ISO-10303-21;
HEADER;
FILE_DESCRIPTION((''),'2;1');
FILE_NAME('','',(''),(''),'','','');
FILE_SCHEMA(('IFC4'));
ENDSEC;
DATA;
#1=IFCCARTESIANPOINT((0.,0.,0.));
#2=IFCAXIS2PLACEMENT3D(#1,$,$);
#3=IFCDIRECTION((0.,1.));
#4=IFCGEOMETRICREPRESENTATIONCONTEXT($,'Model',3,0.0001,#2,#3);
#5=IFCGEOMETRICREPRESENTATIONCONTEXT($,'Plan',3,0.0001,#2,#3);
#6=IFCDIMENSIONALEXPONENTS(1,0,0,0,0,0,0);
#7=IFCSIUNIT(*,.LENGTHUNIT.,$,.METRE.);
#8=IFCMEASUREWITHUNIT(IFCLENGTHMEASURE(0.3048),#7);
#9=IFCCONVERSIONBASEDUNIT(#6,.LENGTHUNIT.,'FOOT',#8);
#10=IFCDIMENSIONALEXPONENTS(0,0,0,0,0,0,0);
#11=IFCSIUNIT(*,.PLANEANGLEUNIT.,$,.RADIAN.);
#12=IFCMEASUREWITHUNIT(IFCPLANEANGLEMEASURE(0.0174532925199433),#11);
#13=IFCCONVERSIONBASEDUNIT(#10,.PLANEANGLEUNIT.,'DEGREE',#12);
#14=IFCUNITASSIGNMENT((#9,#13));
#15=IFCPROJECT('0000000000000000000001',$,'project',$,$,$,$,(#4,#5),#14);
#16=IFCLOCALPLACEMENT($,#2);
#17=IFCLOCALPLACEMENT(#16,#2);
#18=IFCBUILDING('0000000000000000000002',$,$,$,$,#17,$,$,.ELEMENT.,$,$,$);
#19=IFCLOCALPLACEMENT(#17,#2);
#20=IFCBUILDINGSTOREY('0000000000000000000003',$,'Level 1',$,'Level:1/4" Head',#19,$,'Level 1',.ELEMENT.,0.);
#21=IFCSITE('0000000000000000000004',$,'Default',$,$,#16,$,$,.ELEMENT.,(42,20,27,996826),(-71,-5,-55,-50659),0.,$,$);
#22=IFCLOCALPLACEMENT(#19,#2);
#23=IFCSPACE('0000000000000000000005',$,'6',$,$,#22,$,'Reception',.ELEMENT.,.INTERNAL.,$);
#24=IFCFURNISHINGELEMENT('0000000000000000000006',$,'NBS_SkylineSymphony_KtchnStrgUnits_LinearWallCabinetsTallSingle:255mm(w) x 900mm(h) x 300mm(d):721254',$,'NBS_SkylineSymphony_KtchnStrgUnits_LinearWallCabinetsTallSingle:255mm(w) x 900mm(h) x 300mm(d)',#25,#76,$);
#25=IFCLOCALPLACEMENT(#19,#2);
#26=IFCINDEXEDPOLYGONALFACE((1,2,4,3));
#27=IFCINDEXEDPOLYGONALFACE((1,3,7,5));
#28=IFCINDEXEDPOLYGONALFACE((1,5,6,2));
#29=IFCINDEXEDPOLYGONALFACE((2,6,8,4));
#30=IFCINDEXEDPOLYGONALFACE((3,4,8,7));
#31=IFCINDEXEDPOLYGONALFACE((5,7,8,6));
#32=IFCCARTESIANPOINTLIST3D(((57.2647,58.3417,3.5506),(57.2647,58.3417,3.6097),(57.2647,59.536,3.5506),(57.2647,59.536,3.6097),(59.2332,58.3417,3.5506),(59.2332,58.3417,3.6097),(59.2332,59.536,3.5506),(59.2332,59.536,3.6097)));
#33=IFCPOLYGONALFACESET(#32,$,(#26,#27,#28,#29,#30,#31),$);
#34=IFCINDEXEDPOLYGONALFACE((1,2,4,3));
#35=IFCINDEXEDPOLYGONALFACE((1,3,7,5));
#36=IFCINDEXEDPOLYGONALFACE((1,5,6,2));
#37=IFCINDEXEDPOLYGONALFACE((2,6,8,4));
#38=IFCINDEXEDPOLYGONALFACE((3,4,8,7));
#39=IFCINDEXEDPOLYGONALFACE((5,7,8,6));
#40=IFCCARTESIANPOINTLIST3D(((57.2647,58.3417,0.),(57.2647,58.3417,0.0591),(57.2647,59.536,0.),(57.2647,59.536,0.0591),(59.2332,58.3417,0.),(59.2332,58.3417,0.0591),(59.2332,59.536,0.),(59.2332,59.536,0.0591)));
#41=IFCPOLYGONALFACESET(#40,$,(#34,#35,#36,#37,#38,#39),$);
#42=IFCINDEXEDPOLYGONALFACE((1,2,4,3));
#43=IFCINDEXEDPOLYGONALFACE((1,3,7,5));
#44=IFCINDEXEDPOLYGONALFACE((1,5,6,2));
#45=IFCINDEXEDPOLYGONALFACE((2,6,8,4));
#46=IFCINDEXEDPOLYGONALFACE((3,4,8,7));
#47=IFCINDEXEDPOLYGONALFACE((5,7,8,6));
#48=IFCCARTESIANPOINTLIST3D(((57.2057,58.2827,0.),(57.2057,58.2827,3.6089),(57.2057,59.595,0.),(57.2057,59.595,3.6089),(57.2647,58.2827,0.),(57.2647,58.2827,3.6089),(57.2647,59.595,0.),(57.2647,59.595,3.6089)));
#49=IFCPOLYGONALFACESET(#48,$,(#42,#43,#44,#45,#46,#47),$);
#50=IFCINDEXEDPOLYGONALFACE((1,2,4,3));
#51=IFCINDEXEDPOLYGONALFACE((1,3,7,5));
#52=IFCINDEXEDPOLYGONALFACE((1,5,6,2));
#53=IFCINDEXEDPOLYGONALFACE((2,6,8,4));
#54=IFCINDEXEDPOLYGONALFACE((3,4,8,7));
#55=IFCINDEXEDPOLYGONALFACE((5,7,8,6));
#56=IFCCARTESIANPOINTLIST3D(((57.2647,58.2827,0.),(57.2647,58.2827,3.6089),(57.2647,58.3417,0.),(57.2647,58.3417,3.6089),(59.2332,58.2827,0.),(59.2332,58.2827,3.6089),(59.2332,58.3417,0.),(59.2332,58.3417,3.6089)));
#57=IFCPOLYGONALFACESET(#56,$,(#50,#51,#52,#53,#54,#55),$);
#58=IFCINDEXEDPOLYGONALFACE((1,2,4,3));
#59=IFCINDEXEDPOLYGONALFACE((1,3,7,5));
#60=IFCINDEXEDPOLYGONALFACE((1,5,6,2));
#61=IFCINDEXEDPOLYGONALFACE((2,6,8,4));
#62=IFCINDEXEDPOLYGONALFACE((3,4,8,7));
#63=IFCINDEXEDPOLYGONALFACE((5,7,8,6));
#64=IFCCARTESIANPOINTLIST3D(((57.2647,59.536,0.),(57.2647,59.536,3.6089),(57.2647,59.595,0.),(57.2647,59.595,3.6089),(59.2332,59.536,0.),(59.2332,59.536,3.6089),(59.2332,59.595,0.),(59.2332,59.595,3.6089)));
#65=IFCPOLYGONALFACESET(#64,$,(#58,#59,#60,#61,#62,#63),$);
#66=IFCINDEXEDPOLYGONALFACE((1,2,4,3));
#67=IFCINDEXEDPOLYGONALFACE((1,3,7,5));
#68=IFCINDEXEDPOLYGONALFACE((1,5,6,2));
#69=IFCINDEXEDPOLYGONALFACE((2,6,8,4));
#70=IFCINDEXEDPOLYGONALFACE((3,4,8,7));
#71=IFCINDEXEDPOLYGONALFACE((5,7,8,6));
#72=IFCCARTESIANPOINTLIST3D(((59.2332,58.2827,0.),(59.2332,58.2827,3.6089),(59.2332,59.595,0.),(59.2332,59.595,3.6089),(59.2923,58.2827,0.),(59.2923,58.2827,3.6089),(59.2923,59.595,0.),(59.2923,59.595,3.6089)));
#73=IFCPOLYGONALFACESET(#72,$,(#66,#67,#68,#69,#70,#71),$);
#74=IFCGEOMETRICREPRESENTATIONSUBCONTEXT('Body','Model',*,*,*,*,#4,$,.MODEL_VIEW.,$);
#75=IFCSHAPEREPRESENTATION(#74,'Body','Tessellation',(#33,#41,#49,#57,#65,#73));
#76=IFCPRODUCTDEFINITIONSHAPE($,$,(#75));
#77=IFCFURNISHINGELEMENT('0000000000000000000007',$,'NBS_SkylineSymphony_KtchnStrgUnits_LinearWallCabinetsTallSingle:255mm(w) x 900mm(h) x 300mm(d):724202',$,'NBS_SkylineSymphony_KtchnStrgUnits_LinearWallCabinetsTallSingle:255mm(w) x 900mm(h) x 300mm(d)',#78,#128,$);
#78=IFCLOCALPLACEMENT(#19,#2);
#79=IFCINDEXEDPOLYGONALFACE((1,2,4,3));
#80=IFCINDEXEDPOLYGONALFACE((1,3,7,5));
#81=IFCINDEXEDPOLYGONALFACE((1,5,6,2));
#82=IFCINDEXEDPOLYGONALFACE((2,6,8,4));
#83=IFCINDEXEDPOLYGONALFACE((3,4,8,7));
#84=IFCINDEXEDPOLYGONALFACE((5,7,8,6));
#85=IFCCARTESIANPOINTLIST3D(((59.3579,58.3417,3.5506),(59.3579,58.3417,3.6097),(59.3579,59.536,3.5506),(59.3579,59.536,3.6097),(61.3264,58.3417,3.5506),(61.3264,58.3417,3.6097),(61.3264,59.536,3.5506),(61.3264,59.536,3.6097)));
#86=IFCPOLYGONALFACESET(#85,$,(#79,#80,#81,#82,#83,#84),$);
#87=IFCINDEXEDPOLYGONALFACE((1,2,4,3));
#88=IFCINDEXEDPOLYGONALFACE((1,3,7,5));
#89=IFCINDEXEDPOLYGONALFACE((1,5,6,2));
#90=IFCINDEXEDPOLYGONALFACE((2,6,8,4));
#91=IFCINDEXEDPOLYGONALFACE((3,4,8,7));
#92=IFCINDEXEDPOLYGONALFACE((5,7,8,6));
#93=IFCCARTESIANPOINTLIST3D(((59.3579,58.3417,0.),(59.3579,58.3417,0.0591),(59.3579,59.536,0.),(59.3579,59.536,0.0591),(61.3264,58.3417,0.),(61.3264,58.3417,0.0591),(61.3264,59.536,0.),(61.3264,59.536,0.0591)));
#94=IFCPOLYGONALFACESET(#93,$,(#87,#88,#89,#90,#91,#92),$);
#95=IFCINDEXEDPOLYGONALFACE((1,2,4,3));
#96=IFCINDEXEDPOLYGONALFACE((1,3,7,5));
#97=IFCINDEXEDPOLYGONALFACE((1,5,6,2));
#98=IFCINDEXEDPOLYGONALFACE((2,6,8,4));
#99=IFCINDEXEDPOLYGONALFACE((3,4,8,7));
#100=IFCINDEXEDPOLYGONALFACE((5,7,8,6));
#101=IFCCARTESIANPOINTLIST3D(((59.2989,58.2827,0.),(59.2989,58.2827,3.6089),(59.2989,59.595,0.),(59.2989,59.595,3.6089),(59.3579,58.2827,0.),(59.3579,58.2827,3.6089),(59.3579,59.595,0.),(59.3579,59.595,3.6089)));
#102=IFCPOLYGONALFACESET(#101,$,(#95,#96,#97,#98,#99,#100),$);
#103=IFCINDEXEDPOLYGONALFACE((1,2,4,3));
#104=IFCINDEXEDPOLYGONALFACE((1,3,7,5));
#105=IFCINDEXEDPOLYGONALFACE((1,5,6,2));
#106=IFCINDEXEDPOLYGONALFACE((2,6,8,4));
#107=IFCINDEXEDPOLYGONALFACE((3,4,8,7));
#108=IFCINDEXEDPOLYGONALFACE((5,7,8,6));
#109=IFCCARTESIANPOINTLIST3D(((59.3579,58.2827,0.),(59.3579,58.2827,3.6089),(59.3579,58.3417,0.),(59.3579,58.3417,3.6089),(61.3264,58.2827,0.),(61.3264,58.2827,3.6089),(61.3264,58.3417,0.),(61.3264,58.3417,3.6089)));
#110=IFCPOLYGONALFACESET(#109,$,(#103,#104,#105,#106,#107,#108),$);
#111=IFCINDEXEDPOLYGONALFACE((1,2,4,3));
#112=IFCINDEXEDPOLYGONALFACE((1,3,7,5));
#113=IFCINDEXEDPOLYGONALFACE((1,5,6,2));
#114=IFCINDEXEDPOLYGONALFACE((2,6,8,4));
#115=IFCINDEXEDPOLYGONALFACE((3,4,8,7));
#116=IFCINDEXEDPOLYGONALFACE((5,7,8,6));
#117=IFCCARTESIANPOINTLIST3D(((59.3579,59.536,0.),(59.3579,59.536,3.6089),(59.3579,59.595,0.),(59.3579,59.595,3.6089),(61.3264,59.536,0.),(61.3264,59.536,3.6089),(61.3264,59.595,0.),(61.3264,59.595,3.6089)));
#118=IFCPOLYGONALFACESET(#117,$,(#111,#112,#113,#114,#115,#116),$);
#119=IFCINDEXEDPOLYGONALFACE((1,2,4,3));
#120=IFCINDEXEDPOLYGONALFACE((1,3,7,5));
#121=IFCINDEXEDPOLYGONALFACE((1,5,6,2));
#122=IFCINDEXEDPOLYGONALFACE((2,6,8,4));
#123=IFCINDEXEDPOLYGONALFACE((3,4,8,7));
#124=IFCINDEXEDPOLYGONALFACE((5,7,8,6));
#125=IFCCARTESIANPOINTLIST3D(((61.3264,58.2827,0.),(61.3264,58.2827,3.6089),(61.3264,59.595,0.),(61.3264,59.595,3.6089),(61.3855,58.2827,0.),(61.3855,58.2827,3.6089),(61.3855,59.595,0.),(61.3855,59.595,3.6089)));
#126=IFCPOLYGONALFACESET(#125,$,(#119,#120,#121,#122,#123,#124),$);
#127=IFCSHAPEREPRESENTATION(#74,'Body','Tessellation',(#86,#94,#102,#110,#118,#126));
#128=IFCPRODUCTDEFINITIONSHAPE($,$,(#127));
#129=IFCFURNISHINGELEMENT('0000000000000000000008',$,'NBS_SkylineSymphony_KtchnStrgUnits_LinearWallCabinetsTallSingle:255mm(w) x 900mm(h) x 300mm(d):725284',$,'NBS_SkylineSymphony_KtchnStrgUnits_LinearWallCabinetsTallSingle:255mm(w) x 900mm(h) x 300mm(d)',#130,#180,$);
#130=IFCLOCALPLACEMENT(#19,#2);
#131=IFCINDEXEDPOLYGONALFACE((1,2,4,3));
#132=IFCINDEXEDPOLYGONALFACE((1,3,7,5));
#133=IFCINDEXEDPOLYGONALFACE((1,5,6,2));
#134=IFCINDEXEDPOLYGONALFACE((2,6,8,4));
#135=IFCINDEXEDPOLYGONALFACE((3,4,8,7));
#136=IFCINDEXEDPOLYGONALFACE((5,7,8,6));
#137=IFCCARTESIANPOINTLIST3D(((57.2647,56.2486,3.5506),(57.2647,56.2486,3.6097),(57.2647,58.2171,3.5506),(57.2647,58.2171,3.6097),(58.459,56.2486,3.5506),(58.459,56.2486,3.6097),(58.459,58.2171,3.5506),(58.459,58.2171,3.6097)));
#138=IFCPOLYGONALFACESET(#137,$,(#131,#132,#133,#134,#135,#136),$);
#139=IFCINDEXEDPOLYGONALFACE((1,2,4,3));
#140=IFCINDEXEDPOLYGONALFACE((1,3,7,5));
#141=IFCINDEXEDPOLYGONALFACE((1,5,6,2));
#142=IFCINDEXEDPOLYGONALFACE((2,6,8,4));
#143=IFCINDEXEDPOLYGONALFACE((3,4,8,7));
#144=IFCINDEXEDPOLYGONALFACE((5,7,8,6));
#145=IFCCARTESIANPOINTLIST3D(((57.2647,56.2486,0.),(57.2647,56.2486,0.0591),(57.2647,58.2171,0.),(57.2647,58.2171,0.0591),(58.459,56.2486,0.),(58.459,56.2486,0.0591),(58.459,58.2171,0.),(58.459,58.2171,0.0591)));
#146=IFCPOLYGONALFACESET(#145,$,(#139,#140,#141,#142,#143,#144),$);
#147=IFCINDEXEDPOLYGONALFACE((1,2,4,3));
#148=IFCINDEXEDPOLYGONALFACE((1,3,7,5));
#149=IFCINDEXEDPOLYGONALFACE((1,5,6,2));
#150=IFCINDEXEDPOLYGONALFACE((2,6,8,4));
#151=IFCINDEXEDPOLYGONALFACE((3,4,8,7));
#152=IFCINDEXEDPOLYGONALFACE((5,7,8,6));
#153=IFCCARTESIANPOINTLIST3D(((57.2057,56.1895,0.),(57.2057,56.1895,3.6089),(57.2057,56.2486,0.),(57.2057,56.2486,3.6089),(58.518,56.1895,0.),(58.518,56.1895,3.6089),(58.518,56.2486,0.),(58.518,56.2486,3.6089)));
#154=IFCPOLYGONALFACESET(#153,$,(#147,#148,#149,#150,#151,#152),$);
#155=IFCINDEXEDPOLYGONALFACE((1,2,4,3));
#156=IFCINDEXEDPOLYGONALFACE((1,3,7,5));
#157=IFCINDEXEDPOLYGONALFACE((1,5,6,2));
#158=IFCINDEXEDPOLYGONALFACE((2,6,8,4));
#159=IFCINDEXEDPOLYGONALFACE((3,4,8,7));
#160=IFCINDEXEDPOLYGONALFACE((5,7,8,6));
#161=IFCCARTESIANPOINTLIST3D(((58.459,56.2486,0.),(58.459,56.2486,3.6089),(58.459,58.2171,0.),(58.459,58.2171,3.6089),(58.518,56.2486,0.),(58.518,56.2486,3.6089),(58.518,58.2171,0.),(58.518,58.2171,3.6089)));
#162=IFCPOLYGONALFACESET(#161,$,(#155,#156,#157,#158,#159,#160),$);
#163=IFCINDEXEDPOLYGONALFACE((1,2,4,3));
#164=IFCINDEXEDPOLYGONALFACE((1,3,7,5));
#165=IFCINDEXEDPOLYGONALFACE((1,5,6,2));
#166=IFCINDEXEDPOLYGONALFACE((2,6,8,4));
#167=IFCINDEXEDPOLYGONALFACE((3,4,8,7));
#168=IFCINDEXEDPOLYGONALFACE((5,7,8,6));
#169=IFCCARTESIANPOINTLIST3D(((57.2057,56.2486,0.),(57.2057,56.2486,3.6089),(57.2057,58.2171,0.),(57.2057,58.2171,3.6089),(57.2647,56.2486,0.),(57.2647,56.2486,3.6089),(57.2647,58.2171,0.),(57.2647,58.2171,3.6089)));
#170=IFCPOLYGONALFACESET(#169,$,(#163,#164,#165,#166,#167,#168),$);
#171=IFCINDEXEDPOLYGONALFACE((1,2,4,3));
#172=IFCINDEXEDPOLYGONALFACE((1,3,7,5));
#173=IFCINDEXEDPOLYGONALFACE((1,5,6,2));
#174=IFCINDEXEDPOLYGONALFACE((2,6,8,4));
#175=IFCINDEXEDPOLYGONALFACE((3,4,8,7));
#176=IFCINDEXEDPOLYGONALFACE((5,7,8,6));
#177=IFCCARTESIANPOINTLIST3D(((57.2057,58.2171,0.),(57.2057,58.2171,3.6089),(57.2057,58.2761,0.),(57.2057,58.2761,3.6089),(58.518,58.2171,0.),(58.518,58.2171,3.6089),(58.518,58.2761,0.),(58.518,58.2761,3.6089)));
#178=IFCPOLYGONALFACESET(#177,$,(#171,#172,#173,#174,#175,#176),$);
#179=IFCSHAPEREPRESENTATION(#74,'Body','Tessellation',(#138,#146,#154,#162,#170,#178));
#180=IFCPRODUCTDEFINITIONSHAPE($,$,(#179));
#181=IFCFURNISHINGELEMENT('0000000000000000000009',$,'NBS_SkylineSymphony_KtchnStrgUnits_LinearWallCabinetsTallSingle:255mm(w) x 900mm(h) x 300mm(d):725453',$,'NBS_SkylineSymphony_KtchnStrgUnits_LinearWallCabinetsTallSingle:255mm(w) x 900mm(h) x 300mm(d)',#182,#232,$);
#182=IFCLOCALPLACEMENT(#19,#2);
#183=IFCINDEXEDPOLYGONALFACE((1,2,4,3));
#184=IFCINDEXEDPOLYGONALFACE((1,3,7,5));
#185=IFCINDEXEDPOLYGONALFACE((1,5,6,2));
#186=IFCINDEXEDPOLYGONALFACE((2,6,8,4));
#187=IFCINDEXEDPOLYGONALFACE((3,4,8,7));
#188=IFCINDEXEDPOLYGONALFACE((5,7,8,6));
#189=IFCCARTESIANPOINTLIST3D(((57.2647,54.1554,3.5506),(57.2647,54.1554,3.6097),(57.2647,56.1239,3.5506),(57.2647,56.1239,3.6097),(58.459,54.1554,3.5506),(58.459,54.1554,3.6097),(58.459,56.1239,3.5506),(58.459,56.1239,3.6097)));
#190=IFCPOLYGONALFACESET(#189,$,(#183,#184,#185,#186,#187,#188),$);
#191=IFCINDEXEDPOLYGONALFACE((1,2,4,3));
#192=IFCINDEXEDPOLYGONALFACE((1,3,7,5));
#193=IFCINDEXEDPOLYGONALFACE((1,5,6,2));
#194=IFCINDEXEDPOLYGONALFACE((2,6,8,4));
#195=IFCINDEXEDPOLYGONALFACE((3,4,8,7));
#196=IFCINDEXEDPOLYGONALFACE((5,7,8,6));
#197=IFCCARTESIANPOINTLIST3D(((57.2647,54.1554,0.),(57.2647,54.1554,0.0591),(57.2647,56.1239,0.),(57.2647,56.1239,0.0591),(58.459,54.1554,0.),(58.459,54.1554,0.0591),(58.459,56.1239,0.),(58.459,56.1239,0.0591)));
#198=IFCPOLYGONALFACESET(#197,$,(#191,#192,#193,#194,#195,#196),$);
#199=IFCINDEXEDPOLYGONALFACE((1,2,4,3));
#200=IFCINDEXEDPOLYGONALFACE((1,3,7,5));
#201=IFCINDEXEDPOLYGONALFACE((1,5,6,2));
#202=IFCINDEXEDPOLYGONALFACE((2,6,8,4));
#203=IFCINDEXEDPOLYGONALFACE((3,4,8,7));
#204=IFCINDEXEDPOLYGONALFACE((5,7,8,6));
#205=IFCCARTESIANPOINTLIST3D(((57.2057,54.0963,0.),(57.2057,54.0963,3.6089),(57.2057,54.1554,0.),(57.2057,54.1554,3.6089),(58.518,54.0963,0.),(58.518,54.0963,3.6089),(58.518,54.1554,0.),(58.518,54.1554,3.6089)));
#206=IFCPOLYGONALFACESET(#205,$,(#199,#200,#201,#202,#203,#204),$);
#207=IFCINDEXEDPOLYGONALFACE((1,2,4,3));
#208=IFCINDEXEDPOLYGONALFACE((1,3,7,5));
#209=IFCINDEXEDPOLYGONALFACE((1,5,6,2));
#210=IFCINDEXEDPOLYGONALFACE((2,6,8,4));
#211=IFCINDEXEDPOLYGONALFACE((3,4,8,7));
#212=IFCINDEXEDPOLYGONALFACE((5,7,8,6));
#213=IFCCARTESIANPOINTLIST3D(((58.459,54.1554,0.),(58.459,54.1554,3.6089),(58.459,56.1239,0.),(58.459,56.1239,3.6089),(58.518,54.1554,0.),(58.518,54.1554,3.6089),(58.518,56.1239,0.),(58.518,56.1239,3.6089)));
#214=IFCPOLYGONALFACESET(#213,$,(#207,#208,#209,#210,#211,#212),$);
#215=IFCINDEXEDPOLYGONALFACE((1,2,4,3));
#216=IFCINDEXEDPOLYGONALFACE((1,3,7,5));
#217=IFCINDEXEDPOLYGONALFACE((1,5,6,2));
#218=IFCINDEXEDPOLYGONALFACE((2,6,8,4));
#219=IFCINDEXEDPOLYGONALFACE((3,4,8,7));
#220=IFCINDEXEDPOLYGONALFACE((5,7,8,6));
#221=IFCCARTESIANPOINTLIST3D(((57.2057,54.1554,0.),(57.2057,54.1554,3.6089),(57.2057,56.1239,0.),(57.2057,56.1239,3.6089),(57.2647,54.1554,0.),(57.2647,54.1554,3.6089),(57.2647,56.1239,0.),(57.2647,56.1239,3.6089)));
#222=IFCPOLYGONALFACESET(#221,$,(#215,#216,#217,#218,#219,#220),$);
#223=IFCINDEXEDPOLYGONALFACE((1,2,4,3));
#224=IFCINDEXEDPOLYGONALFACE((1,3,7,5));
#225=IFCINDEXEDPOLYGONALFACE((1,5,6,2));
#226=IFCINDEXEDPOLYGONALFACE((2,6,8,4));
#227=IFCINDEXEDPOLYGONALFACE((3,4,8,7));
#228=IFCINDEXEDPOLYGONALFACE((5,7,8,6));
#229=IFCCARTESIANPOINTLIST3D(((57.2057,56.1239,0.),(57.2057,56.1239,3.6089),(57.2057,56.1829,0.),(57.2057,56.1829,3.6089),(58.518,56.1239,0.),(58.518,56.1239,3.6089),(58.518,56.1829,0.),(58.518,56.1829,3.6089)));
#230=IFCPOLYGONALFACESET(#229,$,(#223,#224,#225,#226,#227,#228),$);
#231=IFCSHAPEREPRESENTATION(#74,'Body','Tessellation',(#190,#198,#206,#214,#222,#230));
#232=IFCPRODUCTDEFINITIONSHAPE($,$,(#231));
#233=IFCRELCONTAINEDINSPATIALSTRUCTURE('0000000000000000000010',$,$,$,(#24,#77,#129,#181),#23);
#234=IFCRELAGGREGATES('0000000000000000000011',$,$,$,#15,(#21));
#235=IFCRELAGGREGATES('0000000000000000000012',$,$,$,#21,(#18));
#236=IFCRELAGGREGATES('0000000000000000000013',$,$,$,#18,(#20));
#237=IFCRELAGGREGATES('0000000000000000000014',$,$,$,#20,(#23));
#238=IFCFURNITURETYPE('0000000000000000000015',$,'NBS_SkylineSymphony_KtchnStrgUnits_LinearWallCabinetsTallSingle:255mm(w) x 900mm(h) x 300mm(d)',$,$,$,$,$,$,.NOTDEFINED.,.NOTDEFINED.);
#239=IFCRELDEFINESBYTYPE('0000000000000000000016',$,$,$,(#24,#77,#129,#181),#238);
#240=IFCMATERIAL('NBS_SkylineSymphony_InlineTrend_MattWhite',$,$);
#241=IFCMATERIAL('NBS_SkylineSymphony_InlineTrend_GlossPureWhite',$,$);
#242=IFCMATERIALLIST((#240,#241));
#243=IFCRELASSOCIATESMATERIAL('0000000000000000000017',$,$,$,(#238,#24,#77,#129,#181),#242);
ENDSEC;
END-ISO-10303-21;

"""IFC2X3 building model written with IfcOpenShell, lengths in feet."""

from ifc_helpers import new_model, entity, si_unit, converted_unit, direction, frame, frame_2d, origin, origin_2d_with_axis, place, context, subcontext, project, spatial, rectangle, extrude, source, transform, mapped, material, material_list, type_object, type_shapes, element, save


model = new_model("IFC2X3")

# Units and contexts
model_context = context("Model", 3, precision=0.0001, world=origin(), true_north=direction((0.0, 1.0)))
plan_context = context("Plan", 3, precision=0.0001, world=origin(), true_north=direction((0.0, 1.0)))
body_context = subcontext(model_context, "Body", "Model", "MODEL_VIEW")
ifc_project = project(units=[converted_unit("LENGTHUNIT", "FOOT", entity("IfcLengthMeasure", 0.3048), si_unit("LENGTHUNIT", "METRE"), dimensions=[1, 0, 0, 0, 0, 0, 0]), converted_unit("PLANEANGLEUNIT", "DEGREE", entity("IfcPlaneAngleMeasure", 0.0174532925199433), si_unit("PLANEANGLEUNIT", "RADIAN"), dimensions=[0, 0, 0, 0, 0, 0, 0])], contexts=[model_context, plan_context])

# Site, building, storey
site_placement = place(None, origin())
site = spatial("IfcSite", under=ifc_project, at=site_placement, Name="Default", CompositionType="ELEMENT", RefLatitude=(42, 20, 27, 996826), RefLongitude=(-71, -5, -55, -50659), RefElevation=0.0)
building_placement = place(site_placement, origin())
building = spatial("IfcBuilding", under=site, at=building_placement, CompositionType="ELEMENT")
storey_placement = place(building_placement, origin())
storey = spatial("IfcBuildingStorey", under=building, at=storey_placement, Name="Level 1", ObjectType="Level:1/4\" Head", LongName="Level 1", CompositionType="ELEMENT", Elevation=0.0)

# Shared definitions
space_1_placement = place(storey_placement, origin())
space_1 = spatial("IfcSpace", under=storey, at=space_1_placement, Name="6", LongName="Reception", CompositionType="ELEMENT", InteriorOrExteriorSpace="INTERNAL")

# Furnishing elements
ifc_material_1 = material(Name="NBS_SkylineSymphony_InlineTrend_MattWhite")
ifc_material_2 = material(Name="NBS_SkylineSymphony_InlineTrend_GlossPureWhite")
ifc_material_list = material_list([ifc_material_1, ifc_material_2])
furniture_type_1 = type_object("IfcFurnitureType", Name="NBS_SkylineSymphony_KtchnStrgUnits_LinearWallCabinetsTallSingle:255mm(w) x 900mm(h) x 300mm(d)", AssemblyPlace="NOTDEFINED", material=ifc_material_list)
shared_shape_1 = source(origin(), body_context, "Body", "SweptSolid", [
    extrude(rectangle(XDim=1.9685, YDim=1.1942, at=origin_2d_with_axis()), frame((-0.2379, 0.0, 3.5506), z_axis=(0.0, 0.0, 1.0), x_axis=(0.0, 1.0, 0.0)), (0.0, 0.0, 1.0), 0.0591),
    extrude(rectangle(XDim=1.9685, YDim=1.1942, at=origin_2d_with_axis()), frame((-0.2379, 0.0, 0.0), z_axis=(0.0, 0.0, 1.0), x_axis=(0.0, 1.0, 0.0)), (0.0, 0.0, 1.0), 0.0591),
    extrude(rectangle(XDim=1.3123, YDim=0.0591, at=origin_2d_with_axis()), frame((-0.2379, 1.0138, 0.0), z_axis=(0.0, 0.0, 1.0), x_axis=(-1.0, 0.0, 0.0)), (0.0, 0.0, 1.0), 3.6089),
    extrude(rectangle(XDim=1.9685, YDim=0.0591, at=origin_2d_with_axis()), frame((-0.8645, 0.0, 0.0), z_axis=(0.0, 0.0, 1.0), x_axis=(0.0, -1.0, 0.0)), (0.0, 0.0, 1.0), 3.6089),
    extrude(rectangle(XDim=0.0591, YDim=1.9685, at=origin_2d_with_axis()), frame((0.3888, 0.0, 0.0)), (0.0, 0.0, 1.0), 3.6089),
    extrude(rectangle(XDim=0.0591, YDim=1.3123, at=frame_2d((0.0, 0.0), x_axis=(1.0, 0.0))), frame((-0.2379, -1.0138, 0.0), z_axis=(0.0, 0.0, 1.0), x_axis=(0.0, 1.0, 0.0)), (0.0, 0.0, 1.0), 3.6089),
])
type_shapes(furniture_type_1, [shared_shape_1])
for number, where, z_axis, x_axis, name in (
    (1, (58.249, 59.1767, 0.0), (0.0, 0.0, 1.0), (0.0, 1.0, 0.0), "NBS_SkylineSymphony_KtchnStrgUnits_LinearWallCabinetsTallSingle:255mm(w) x 900mm(h) x 300mm(d):721254"),
    (2, (60.3422, 59.1767, 0.0), (0.0, 0.0, 1.0), (0.0, 1.0, 0.0), "NBS_SkylineSymphony_KtchnStrgUnits_LinearWallCabinetsTallSingle:255mm(w) x 900mm(h) x 300mm(d):724202"),
    (3, (57.624, 57.2328, 0.0), (0.0, 0.0, 1.0), (-1.0, 0.0, 0.0), "NBS_SkylineSymphony_KtchnStrgUnits_LinearWallCabinetsTallSingle:255mm(w) x 900mm(h) x 300mm(d):725284"),
    (4, (57.624, 55.1396, 0.0), (0.0, 0.0, 1.0), (-1.0, 0.0, 0.0), "NBS_SkylineSymphony_KtchnStrgUnits_LinearWallCabinetsTallSingle:255mm(w) x 900mm(h) x 300mm(d):725453"),
):
    element("IfcFurnishingElement", number, at=place(space_1_placement, frame(where, z_axis=z_axis, x_axis=x_axis)), inside=space_1, type_object=furniture_type_1, material=ifc_material_list, Name=name, ObjectType="NBS_SkylineSymphony_KtchnStrgUnits_LinearWallCabinetsTallSingle:255mm(w) x 900mm(h) x 300mm(d)", context=body_context, shape_type="MappedRepresentation", body=[
        mapped(shared_shape_1, transform((0.0, 0.0, 0.0), scale=1.0)),
    ])

save(model, "model.ifc")
